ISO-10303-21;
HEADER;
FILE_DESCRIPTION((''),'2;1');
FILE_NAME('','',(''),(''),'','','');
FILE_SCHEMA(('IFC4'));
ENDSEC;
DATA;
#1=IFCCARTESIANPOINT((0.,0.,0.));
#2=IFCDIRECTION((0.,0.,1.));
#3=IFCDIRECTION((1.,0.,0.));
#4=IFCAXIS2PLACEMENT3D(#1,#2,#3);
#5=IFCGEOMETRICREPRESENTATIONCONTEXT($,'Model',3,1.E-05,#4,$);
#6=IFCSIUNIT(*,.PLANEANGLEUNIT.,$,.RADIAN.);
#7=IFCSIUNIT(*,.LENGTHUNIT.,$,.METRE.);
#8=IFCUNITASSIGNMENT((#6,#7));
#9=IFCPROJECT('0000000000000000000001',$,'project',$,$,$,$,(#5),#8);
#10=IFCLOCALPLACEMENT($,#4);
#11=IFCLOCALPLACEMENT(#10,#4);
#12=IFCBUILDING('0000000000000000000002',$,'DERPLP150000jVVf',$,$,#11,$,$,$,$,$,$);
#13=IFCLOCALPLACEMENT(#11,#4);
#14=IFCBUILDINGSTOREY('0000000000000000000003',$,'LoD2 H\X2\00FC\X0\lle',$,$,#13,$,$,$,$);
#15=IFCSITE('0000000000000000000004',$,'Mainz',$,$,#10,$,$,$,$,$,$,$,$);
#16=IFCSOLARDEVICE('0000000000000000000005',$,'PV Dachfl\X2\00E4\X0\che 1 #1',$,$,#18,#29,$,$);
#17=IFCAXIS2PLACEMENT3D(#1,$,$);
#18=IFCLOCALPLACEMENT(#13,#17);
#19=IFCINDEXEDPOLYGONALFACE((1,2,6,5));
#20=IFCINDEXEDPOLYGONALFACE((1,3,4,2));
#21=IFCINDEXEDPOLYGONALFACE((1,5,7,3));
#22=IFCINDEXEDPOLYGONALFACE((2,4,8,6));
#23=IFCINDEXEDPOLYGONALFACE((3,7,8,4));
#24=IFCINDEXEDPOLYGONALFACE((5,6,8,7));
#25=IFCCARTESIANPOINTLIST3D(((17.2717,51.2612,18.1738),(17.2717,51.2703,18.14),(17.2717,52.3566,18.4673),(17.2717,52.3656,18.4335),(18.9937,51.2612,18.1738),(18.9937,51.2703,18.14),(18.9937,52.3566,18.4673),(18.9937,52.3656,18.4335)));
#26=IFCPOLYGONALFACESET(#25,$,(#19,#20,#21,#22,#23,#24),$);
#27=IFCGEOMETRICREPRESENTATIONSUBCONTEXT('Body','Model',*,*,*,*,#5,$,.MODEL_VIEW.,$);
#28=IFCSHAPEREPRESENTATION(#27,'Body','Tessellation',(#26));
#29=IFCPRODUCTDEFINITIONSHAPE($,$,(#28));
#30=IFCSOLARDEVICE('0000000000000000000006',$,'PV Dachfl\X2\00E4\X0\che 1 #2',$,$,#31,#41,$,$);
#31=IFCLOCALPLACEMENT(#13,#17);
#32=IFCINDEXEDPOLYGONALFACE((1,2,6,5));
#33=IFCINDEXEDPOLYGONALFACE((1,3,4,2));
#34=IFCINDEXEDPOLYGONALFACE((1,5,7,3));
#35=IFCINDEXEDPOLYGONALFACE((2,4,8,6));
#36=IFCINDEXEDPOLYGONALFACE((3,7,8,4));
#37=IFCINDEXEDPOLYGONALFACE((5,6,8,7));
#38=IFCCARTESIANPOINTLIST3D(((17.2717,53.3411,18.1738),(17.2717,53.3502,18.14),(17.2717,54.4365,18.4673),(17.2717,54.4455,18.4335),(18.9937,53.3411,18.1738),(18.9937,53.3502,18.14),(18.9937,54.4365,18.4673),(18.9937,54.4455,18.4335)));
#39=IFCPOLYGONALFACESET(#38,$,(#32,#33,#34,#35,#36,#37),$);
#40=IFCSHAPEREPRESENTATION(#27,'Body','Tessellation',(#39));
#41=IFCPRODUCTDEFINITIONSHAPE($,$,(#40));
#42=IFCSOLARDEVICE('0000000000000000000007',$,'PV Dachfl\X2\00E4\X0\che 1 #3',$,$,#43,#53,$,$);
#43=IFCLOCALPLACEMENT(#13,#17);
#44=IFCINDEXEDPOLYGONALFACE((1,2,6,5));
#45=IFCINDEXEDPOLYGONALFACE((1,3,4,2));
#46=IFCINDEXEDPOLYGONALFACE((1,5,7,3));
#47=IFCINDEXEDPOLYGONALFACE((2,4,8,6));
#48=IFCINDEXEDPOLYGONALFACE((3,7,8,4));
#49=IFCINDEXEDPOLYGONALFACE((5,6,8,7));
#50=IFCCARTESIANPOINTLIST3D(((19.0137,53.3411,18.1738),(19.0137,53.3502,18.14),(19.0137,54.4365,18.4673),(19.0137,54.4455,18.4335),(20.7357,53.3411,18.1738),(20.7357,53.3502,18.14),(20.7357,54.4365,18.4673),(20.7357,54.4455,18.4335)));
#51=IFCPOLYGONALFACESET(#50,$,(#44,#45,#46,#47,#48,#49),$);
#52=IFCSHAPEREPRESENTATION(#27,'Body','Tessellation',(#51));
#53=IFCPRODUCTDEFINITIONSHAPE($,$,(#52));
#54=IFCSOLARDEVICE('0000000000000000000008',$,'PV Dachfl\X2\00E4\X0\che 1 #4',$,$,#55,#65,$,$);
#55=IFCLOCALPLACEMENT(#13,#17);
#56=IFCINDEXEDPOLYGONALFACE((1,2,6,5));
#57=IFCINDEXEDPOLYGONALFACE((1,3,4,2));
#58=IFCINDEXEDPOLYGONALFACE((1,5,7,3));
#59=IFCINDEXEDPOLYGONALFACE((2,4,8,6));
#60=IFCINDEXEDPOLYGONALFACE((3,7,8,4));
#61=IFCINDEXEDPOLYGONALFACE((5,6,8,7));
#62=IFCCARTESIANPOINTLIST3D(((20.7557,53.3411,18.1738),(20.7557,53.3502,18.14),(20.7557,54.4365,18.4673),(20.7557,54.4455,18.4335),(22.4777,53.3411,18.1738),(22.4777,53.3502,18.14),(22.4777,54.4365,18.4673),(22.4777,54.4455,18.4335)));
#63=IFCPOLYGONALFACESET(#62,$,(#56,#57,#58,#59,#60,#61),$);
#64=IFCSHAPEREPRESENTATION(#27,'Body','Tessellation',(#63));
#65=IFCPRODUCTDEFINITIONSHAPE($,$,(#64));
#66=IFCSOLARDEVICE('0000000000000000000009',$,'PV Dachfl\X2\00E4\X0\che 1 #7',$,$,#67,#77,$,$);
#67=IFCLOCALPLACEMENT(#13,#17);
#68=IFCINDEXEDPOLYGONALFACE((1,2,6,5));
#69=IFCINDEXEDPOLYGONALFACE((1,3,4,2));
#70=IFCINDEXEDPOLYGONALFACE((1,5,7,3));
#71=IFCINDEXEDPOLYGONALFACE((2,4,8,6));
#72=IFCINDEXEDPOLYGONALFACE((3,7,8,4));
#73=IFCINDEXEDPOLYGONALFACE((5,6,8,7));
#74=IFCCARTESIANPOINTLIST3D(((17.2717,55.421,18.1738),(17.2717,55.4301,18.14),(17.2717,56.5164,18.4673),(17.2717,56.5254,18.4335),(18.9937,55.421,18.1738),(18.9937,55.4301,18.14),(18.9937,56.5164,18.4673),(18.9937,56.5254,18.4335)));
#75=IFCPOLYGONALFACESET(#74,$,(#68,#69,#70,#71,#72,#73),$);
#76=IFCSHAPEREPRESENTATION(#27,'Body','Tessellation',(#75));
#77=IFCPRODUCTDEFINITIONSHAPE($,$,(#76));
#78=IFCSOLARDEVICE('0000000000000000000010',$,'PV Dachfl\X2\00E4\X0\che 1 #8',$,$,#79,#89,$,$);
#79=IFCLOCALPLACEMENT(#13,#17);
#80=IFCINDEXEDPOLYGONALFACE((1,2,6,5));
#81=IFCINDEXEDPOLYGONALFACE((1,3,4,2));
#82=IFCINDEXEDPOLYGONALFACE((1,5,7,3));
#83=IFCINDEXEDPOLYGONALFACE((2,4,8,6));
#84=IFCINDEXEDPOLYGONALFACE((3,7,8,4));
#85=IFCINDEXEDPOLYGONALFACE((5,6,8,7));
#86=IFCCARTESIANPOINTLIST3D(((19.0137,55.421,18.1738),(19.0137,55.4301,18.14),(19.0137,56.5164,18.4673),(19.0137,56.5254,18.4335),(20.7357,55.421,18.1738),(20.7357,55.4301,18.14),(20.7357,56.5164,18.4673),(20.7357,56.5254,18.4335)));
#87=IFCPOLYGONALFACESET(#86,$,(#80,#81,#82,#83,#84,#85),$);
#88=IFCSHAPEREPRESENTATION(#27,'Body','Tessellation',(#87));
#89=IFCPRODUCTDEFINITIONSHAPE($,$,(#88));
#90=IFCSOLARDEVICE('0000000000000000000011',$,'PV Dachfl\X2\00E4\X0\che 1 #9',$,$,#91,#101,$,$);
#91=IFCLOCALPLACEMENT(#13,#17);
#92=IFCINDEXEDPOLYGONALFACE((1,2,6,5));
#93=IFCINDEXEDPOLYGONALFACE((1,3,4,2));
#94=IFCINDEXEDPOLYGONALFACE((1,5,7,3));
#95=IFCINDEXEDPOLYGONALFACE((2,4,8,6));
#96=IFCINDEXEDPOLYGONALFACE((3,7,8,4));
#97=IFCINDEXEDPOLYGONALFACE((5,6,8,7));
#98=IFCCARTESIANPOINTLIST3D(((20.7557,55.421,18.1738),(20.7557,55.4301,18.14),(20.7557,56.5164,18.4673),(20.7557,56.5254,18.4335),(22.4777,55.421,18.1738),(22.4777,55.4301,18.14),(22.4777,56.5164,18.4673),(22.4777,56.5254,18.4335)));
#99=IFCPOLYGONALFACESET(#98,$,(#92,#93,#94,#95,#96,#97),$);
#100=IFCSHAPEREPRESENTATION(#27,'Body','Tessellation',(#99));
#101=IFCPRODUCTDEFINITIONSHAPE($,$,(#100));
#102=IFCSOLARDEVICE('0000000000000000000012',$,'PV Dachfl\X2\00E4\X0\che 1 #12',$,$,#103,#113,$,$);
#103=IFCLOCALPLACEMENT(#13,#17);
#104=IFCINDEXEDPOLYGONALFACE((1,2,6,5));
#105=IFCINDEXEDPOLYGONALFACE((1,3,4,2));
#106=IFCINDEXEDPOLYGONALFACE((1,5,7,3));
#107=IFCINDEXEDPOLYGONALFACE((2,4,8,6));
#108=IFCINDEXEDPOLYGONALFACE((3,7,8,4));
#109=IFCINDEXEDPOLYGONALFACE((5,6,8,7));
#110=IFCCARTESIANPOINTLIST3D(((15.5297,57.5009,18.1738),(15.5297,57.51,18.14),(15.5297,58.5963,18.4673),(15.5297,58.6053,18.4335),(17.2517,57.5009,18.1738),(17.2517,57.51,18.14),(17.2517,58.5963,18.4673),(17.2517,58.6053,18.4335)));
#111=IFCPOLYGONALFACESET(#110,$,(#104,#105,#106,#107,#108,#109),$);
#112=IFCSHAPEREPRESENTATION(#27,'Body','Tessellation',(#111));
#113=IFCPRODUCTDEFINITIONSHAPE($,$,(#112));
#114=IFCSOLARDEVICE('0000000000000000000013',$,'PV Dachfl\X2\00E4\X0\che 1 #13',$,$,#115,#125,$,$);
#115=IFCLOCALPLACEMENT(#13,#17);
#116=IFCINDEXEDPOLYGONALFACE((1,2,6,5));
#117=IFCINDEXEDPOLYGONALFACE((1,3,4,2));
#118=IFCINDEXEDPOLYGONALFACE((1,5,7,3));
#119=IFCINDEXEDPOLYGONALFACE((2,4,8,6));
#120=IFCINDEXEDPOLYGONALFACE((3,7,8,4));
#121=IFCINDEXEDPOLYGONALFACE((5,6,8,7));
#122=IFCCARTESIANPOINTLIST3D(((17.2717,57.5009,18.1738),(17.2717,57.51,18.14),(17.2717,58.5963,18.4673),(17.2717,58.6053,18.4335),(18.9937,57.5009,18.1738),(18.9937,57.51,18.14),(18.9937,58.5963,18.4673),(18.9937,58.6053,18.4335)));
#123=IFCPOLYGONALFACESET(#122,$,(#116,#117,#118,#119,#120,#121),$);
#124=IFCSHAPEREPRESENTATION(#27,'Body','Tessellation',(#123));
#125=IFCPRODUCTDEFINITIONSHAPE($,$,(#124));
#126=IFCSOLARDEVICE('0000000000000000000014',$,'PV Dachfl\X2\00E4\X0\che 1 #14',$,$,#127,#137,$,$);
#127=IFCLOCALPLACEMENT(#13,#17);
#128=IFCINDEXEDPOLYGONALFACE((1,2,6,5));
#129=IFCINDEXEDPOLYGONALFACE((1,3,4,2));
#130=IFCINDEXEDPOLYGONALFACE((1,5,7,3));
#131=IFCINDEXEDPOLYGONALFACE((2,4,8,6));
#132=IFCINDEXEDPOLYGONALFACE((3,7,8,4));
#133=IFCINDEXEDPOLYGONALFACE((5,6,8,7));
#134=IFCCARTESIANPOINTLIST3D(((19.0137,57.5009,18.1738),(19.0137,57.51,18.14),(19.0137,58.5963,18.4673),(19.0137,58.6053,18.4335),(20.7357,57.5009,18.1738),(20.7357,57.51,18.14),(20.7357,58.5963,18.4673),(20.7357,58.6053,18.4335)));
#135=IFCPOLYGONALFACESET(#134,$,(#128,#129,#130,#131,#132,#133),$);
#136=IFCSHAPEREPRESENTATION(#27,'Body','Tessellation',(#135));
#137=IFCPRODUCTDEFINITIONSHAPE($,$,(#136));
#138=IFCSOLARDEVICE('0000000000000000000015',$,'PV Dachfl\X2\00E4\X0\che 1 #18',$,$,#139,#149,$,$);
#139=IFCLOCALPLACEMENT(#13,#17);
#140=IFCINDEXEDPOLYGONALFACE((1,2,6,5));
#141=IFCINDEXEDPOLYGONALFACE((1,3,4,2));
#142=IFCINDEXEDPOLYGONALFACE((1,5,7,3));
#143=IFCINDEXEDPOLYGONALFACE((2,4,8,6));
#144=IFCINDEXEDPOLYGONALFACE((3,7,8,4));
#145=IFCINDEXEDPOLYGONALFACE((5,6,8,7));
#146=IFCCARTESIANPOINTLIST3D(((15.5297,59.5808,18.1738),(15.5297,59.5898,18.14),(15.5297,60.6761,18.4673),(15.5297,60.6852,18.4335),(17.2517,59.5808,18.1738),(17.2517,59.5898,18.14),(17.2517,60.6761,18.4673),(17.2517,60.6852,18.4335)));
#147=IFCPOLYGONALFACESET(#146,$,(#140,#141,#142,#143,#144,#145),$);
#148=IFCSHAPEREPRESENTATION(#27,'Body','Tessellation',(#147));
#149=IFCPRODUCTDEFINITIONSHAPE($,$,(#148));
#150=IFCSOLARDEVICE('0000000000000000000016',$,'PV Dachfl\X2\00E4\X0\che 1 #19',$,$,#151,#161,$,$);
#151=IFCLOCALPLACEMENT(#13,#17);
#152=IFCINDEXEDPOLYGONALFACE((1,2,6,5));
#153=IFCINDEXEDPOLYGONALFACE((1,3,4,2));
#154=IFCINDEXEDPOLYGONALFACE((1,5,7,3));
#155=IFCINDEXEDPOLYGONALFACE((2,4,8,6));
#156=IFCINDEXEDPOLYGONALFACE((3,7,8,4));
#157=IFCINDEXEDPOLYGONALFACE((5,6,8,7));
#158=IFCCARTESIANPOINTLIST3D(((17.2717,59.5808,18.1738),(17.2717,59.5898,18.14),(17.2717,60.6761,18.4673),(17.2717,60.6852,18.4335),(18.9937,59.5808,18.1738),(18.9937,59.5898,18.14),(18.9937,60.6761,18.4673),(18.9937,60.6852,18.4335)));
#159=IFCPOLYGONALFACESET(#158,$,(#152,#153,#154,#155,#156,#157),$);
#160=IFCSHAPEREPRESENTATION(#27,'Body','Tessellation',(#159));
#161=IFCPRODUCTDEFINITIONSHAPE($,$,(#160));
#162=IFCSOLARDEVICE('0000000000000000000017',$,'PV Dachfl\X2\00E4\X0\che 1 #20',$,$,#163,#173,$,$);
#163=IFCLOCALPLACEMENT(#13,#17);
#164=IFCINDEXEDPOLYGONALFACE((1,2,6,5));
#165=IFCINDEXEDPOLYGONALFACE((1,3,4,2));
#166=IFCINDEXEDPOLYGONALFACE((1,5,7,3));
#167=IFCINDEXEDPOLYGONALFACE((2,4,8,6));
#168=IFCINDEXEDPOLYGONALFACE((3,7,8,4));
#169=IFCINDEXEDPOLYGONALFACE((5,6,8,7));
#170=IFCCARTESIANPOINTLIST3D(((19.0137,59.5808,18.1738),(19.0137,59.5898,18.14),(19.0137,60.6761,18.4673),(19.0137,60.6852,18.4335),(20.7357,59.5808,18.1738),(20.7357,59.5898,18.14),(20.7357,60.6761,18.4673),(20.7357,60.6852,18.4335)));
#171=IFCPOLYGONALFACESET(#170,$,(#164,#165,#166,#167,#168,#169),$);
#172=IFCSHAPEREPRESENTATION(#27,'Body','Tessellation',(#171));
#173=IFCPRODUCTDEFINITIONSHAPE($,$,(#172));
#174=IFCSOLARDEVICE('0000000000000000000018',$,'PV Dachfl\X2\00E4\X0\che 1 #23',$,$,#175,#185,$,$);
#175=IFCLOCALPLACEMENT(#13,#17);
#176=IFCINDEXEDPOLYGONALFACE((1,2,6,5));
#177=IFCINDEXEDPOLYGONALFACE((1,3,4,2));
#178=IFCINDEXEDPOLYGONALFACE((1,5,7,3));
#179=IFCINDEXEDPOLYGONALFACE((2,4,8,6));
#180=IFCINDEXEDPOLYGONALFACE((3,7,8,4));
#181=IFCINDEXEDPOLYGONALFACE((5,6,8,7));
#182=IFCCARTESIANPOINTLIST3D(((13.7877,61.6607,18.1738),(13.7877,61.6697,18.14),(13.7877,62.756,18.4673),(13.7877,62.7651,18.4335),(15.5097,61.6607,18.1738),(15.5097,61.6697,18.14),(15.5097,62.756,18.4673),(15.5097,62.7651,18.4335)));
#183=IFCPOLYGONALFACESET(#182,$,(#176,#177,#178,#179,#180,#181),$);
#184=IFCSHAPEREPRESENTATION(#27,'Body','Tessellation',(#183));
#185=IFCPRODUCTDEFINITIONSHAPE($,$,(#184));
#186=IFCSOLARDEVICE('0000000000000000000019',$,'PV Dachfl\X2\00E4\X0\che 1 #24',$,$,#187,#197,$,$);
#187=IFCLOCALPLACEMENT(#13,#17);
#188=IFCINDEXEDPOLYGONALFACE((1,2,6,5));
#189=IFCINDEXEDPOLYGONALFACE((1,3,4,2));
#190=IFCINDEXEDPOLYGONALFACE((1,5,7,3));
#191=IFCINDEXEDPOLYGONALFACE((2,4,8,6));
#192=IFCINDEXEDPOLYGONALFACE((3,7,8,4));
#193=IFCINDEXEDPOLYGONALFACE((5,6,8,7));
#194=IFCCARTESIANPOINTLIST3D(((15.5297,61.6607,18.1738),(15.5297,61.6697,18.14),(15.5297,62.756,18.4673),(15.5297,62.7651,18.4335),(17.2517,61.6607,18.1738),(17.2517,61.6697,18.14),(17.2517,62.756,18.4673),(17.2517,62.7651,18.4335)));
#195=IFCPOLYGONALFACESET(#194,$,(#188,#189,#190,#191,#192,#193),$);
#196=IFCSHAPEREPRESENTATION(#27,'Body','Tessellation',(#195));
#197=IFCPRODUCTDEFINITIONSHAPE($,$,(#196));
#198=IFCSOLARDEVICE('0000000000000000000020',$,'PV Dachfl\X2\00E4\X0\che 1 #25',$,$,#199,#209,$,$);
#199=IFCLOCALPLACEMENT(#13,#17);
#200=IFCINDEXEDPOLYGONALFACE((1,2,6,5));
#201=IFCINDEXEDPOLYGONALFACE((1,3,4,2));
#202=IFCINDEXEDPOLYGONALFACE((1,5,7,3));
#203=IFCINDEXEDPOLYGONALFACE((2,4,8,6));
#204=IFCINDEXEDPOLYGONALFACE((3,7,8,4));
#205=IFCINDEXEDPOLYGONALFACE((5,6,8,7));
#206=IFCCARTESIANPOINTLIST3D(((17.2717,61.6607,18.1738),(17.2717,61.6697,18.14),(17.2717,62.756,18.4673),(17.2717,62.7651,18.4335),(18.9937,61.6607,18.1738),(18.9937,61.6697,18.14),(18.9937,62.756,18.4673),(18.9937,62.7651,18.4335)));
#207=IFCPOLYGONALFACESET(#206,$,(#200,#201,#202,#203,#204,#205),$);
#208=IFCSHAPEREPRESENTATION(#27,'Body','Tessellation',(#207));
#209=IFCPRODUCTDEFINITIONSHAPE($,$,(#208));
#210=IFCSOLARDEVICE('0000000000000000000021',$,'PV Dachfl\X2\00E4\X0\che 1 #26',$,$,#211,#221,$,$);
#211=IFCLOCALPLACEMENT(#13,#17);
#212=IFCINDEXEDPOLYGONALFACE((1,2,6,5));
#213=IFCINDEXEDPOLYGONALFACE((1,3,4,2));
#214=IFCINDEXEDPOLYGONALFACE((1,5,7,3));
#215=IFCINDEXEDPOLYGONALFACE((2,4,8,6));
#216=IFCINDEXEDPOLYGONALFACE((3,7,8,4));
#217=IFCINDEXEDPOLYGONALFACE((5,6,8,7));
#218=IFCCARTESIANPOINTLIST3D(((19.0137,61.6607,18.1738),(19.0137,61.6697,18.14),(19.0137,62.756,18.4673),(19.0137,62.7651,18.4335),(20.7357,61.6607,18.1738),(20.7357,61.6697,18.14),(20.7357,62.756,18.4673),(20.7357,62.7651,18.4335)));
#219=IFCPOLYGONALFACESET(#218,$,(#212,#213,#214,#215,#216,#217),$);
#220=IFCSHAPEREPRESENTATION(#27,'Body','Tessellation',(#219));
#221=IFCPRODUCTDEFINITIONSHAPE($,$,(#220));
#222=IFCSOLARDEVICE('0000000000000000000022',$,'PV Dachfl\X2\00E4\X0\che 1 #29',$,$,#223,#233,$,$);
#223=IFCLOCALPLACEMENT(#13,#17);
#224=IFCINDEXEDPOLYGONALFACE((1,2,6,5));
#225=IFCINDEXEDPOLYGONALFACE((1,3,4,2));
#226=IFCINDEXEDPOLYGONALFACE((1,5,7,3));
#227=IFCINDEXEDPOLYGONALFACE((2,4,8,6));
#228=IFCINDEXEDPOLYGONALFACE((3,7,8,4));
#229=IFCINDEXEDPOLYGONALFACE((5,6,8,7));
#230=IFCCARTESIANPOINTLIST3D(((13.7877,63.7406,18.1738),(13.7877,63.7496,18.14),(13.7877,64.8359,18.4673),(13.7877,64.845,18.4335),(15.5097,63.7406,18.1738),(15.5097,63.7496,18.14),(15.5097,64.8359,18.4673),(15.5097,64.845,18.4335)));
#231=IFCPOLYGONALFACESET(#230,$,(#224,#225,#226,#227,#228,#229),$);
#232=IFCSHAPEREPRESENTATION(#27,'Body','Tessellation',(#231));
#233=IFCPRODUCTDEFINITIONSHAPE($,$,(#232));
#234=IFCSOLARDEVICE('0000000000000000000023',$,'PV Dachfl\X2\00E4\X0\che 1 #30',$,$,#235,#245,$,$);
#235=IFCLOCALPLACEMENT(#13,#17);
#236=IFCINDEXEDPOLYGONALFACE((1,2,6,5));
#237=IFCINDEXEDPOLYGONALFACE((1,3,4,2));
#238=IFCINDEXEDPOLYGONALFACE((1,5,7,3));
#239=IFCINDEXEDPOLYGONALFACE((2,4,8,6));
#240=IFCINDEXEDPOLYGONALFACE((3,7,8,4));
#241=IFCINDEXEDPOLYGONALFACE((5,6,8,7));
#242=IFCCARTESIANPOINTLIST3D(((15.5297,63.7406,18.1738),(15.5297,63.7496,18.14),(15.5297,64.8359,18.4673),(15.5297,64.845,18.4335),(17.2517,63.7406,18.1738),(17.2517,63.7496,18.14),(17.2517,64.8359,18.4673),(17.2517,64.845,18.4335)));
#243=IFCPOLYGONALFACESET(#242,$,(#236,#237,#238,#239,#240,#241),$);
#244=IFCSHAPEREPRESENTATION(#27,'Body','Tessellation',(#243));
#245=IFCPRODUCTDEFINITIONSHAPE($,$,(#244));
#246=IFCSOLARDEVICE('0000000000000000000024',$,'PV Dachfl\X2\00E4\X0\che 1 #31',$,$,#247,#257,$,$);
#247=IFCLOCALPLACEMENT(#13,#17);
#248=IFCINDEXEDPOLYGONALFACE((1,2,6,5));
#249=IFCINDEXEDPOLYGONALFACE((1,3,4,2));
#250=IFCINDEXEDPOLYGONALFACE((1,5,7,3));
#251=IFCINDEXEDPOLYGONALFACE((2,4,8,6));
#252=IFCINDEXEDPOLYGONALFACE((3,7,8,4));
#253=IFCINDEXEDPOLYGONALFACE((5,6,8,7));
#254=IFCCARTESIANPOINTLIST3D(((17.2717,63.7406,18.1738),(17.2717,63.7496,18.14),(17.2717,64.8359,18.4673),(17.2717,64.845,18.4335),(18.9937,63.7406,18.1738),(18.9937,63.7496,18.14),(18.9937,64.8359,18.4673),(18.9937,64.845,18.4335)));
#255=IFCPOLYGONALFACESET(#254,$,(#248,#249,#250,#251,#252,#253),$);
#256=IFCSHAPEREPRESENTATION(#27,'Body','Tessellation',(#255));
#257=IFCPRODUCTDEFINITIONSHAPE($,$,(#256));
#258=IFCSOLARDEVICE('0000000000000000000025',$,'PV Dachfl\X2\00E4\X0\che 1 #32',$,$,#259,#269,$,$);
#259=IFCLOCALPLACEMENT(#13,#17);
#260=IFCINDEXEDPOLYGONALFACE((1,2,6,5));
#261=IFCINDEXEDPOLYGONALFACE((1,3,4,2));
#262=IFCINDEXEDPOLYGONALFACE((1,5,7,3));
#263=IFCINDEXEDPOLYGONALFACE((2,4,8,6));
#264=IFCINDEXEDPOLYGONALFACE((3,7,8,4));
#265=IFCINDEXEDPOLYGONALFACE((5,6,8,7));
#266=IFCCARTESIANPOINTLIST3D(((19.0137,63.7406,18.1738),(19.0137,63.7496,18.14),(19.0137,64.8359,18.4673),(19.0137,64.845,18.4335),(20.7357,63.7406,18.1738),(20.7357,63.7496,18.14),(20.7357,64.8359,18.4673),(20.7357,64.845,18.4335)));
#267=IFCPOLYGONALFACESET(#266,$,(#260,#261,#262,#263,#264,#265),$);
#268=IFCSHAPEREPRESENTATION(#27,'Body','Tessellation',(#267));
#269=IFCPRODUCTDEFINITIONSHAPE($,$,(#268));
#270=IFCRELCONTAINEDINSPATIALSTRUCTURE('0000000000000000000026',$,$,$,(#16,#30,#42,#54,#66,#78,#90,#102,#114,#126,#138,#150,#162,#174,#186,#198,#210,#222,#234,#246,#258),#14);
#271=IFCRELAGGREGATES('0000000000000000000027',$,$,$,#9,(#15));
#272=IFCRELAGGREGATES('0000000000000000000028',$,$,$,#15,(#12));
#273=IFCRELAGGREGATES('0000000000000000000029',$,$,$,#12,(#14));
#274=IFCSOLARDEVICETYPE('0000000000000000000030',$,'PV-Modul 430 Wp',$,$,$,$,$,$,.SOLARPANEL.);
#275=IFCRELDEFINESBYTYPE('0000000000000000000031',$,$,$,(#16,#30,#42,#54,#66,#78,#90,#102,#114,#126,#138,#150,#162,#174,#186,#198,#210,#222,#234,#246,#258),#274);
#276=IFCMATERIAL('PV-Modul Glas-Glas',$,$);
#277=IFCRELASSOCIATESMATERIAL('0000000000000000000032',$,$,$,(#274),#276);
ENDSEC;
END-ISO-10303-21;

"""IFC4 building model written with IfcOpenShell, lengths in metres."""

from ifc_helpers import new_model, si_unit, frame, frame_2d, origin, origin_with_axes, place, context, subcontext, project, spatial, rectangle, extrude, source, transform, mapped, material, type_object, type_shapes, element, save


model = new_model("IFC4")

# Units and contexts
model_context = context("Model", 3, precision=1e-05, world=origin_with_axes())
body_context = subcontext(model_context, "Body", "Model", "MODEL_VIEW")
ifc_project = project(units=[si_unit("PLANEANGLEUNIT", "RADIAN"), si_unit("LENGTHUNIT", "METRE")], contexts=[model_context])

# Site, building, storey
site_placement = place(None, origin_with_axes())
site = spatial("IfcSite", under=ifc_project, at=site_placement, Name="Mainz")
building_placement = place(site_placement, origin_with_axes())
building = spatial("IfcBuilding", under=site, at=building_placement, Name="DERPLP150000jVVf")
storey_placement = place(building_placement, origin_with_axes())
storey = spatial("IfcBuildingStorey", under=building, at=storey_placement, Name="LoD2 Hülle")

# Solar devices
ifc_material = material(Name="PV-Modul Glas-Glas")
solar_device_type = type_object("IfcSolarDeviceType", Name="PV-Modul 430 Wp", PredefinedType="SOLARPANEL", material=ifc_material)
shared_shape = source(origin_with_axes(), body_context, "Body", "SweptSolid", [
    extrude(rectangle(XDim=1.722, YDim=1.134, at=frame_2d((0.861, 0.567))), origin(), (0.0, 0.0, 1.0), 0.035),
])
type_shapes(solar_device_type, [shared_shape])
for number, where, z_axis, x_axis, name in (
    (1, (17.2717, 51.2703, 18.14), (0.0, -0.258819, 0.965926), (1.0, 0.0, 0.0), "PV Dachfläche 1 #1"),
    (2, (17.2717, 53.3502, 18.14), (0.0, -0.258819, 0.965926), (1.0, 0.0, 0.0), "PV Dachfläche 1 #2"),
    (3, (19.0137, 53.3502, 18.14), (0.0, -0.258819, 0.965926), (1.0, 0.0, 0.0), "PV Dachfläche 1 #3"),
    (4, (20.7557, 53.3502, 18.14), (0.0, -0.258819, 0.965926), (1.0, 0.0, 0.0), "PV Dachfläche 1 #4"),
    (5, (17.2717, 55.4301, 18.14), (0.0, -0.258819, 0.965926), (1.0, 0.0, 0.0), "PV Dachfläche 1 #7"),
    (6, (19.0137, 55.4301, 18.14), (0.0, -0.258819, 0.965926), (1.0, 0.0, 0.0), "PV Dachfläche 1 #8"),
    (7, (20.7557, 55.4301, 18.14), (0.0, -0.258819, 0.965926), (1.0, 0.0, 0.0), "PV Dachfläche 1 #9"),
    (8, (15.5297, 57.51, 18.14), (0.0, -0.258819, 0.965926), (1.0, 0.0, 0.0), "PV Dachfläche 1 #12"),
    (9, (17.2717, 57.51, 18.14), (0.0, -0.258819, 0.965926), (1.0, 0.0, 0.0), "PV Dachfläche 1 #13"),
    (10, (19.0137, 57.51, 18.14), (0.0, -0.258819, 0.965926), (1.0, 0.0, 0.0), "PV Dachfläche 1 #14"),
    (11, (15.5297, 59.5898, 18.14), (0.0, -0.258819, 0.965926), (1.0, 0.0, 0.0), "PV Dachfläche 1 #18"),
    (12, (17.2717, 59.5898, 18.14), (0.0, -0.258819, 0.965926), (1.0, 0.0, 0.0), "PV Dachfläche 1 #19"),
    (13, (19.0137, 59.5898, 18.14), (0.0, -0.258819, 0.965926), (1.0, 0.0, 0.0), "PV Dachfläche 1 #20"),
    (14, (13.7877, 61.6697, 18.14), (0.0, -0.258819, 0.965926), (1.0, 0.0, 0.0), "PV Dachfläche 1 #23"),
    (15, (15.5297, 61.6697, 18.14), (0.0, -0.258819, 0.965926), (1.0, 0.0, 0.0), "PV Dachfläche 1 #24"),
    (16, (17.2717, 61.6697, 18.14), (0.0, -0.258819, 0.965926), (1.0, 0.0, 0.0), "PV Dachfläche 1 #25"),
    (17, (19.0137, 61.6697, 18.14), (0.0, -0.258819, 0.965926), (1.0, 0.0, 0.0), "PV Dachfläche 1 #26"),
    (18, (13.7877, 63.7496, 18.14), (0.0, -0.258819, 0.965926), (1.0, 0.0, 0.0), "PV Dachfläche 1 #29"),
    (19, (15.5297, 63.7496, 18.14), (0.0, -0.258819, 0.965926), (1.0, 0.0, 0.0), "PV Dachfläche 1 #30"),
    (20, (17.2717, 63.7496, 18.14), (0.0, -0.258819, 0.965926), (1.0, 0.0, 0.0), "PV Dachfläche 1 #31"),
    (21, (19.0137, 63.7496, 18.14), (0.0, -0.258819, 0.965926), (1.0, 0.0, 0.0), "PV Dachfläche 1 #32"),
):
    element("IfcSolarDevice", number, at=place(storey_placement, frame(where, z_axis=z_axis, x_axis=x_axis)), inside=storey, type_object=solar_device_type, Name=name, context=body_context, shape_type="MappedRepresentation", body=[
        mapped(shared_shape, transform((0.0, 0.0, 0.0), x_axis=(1.0, 0.0, 0.0), y_axis=(0.0, 1.0, 0.0), z_axis=(0.0, 0.0, 1.0), scale=1.0)),
    ])

save(model, "model.ifc")
